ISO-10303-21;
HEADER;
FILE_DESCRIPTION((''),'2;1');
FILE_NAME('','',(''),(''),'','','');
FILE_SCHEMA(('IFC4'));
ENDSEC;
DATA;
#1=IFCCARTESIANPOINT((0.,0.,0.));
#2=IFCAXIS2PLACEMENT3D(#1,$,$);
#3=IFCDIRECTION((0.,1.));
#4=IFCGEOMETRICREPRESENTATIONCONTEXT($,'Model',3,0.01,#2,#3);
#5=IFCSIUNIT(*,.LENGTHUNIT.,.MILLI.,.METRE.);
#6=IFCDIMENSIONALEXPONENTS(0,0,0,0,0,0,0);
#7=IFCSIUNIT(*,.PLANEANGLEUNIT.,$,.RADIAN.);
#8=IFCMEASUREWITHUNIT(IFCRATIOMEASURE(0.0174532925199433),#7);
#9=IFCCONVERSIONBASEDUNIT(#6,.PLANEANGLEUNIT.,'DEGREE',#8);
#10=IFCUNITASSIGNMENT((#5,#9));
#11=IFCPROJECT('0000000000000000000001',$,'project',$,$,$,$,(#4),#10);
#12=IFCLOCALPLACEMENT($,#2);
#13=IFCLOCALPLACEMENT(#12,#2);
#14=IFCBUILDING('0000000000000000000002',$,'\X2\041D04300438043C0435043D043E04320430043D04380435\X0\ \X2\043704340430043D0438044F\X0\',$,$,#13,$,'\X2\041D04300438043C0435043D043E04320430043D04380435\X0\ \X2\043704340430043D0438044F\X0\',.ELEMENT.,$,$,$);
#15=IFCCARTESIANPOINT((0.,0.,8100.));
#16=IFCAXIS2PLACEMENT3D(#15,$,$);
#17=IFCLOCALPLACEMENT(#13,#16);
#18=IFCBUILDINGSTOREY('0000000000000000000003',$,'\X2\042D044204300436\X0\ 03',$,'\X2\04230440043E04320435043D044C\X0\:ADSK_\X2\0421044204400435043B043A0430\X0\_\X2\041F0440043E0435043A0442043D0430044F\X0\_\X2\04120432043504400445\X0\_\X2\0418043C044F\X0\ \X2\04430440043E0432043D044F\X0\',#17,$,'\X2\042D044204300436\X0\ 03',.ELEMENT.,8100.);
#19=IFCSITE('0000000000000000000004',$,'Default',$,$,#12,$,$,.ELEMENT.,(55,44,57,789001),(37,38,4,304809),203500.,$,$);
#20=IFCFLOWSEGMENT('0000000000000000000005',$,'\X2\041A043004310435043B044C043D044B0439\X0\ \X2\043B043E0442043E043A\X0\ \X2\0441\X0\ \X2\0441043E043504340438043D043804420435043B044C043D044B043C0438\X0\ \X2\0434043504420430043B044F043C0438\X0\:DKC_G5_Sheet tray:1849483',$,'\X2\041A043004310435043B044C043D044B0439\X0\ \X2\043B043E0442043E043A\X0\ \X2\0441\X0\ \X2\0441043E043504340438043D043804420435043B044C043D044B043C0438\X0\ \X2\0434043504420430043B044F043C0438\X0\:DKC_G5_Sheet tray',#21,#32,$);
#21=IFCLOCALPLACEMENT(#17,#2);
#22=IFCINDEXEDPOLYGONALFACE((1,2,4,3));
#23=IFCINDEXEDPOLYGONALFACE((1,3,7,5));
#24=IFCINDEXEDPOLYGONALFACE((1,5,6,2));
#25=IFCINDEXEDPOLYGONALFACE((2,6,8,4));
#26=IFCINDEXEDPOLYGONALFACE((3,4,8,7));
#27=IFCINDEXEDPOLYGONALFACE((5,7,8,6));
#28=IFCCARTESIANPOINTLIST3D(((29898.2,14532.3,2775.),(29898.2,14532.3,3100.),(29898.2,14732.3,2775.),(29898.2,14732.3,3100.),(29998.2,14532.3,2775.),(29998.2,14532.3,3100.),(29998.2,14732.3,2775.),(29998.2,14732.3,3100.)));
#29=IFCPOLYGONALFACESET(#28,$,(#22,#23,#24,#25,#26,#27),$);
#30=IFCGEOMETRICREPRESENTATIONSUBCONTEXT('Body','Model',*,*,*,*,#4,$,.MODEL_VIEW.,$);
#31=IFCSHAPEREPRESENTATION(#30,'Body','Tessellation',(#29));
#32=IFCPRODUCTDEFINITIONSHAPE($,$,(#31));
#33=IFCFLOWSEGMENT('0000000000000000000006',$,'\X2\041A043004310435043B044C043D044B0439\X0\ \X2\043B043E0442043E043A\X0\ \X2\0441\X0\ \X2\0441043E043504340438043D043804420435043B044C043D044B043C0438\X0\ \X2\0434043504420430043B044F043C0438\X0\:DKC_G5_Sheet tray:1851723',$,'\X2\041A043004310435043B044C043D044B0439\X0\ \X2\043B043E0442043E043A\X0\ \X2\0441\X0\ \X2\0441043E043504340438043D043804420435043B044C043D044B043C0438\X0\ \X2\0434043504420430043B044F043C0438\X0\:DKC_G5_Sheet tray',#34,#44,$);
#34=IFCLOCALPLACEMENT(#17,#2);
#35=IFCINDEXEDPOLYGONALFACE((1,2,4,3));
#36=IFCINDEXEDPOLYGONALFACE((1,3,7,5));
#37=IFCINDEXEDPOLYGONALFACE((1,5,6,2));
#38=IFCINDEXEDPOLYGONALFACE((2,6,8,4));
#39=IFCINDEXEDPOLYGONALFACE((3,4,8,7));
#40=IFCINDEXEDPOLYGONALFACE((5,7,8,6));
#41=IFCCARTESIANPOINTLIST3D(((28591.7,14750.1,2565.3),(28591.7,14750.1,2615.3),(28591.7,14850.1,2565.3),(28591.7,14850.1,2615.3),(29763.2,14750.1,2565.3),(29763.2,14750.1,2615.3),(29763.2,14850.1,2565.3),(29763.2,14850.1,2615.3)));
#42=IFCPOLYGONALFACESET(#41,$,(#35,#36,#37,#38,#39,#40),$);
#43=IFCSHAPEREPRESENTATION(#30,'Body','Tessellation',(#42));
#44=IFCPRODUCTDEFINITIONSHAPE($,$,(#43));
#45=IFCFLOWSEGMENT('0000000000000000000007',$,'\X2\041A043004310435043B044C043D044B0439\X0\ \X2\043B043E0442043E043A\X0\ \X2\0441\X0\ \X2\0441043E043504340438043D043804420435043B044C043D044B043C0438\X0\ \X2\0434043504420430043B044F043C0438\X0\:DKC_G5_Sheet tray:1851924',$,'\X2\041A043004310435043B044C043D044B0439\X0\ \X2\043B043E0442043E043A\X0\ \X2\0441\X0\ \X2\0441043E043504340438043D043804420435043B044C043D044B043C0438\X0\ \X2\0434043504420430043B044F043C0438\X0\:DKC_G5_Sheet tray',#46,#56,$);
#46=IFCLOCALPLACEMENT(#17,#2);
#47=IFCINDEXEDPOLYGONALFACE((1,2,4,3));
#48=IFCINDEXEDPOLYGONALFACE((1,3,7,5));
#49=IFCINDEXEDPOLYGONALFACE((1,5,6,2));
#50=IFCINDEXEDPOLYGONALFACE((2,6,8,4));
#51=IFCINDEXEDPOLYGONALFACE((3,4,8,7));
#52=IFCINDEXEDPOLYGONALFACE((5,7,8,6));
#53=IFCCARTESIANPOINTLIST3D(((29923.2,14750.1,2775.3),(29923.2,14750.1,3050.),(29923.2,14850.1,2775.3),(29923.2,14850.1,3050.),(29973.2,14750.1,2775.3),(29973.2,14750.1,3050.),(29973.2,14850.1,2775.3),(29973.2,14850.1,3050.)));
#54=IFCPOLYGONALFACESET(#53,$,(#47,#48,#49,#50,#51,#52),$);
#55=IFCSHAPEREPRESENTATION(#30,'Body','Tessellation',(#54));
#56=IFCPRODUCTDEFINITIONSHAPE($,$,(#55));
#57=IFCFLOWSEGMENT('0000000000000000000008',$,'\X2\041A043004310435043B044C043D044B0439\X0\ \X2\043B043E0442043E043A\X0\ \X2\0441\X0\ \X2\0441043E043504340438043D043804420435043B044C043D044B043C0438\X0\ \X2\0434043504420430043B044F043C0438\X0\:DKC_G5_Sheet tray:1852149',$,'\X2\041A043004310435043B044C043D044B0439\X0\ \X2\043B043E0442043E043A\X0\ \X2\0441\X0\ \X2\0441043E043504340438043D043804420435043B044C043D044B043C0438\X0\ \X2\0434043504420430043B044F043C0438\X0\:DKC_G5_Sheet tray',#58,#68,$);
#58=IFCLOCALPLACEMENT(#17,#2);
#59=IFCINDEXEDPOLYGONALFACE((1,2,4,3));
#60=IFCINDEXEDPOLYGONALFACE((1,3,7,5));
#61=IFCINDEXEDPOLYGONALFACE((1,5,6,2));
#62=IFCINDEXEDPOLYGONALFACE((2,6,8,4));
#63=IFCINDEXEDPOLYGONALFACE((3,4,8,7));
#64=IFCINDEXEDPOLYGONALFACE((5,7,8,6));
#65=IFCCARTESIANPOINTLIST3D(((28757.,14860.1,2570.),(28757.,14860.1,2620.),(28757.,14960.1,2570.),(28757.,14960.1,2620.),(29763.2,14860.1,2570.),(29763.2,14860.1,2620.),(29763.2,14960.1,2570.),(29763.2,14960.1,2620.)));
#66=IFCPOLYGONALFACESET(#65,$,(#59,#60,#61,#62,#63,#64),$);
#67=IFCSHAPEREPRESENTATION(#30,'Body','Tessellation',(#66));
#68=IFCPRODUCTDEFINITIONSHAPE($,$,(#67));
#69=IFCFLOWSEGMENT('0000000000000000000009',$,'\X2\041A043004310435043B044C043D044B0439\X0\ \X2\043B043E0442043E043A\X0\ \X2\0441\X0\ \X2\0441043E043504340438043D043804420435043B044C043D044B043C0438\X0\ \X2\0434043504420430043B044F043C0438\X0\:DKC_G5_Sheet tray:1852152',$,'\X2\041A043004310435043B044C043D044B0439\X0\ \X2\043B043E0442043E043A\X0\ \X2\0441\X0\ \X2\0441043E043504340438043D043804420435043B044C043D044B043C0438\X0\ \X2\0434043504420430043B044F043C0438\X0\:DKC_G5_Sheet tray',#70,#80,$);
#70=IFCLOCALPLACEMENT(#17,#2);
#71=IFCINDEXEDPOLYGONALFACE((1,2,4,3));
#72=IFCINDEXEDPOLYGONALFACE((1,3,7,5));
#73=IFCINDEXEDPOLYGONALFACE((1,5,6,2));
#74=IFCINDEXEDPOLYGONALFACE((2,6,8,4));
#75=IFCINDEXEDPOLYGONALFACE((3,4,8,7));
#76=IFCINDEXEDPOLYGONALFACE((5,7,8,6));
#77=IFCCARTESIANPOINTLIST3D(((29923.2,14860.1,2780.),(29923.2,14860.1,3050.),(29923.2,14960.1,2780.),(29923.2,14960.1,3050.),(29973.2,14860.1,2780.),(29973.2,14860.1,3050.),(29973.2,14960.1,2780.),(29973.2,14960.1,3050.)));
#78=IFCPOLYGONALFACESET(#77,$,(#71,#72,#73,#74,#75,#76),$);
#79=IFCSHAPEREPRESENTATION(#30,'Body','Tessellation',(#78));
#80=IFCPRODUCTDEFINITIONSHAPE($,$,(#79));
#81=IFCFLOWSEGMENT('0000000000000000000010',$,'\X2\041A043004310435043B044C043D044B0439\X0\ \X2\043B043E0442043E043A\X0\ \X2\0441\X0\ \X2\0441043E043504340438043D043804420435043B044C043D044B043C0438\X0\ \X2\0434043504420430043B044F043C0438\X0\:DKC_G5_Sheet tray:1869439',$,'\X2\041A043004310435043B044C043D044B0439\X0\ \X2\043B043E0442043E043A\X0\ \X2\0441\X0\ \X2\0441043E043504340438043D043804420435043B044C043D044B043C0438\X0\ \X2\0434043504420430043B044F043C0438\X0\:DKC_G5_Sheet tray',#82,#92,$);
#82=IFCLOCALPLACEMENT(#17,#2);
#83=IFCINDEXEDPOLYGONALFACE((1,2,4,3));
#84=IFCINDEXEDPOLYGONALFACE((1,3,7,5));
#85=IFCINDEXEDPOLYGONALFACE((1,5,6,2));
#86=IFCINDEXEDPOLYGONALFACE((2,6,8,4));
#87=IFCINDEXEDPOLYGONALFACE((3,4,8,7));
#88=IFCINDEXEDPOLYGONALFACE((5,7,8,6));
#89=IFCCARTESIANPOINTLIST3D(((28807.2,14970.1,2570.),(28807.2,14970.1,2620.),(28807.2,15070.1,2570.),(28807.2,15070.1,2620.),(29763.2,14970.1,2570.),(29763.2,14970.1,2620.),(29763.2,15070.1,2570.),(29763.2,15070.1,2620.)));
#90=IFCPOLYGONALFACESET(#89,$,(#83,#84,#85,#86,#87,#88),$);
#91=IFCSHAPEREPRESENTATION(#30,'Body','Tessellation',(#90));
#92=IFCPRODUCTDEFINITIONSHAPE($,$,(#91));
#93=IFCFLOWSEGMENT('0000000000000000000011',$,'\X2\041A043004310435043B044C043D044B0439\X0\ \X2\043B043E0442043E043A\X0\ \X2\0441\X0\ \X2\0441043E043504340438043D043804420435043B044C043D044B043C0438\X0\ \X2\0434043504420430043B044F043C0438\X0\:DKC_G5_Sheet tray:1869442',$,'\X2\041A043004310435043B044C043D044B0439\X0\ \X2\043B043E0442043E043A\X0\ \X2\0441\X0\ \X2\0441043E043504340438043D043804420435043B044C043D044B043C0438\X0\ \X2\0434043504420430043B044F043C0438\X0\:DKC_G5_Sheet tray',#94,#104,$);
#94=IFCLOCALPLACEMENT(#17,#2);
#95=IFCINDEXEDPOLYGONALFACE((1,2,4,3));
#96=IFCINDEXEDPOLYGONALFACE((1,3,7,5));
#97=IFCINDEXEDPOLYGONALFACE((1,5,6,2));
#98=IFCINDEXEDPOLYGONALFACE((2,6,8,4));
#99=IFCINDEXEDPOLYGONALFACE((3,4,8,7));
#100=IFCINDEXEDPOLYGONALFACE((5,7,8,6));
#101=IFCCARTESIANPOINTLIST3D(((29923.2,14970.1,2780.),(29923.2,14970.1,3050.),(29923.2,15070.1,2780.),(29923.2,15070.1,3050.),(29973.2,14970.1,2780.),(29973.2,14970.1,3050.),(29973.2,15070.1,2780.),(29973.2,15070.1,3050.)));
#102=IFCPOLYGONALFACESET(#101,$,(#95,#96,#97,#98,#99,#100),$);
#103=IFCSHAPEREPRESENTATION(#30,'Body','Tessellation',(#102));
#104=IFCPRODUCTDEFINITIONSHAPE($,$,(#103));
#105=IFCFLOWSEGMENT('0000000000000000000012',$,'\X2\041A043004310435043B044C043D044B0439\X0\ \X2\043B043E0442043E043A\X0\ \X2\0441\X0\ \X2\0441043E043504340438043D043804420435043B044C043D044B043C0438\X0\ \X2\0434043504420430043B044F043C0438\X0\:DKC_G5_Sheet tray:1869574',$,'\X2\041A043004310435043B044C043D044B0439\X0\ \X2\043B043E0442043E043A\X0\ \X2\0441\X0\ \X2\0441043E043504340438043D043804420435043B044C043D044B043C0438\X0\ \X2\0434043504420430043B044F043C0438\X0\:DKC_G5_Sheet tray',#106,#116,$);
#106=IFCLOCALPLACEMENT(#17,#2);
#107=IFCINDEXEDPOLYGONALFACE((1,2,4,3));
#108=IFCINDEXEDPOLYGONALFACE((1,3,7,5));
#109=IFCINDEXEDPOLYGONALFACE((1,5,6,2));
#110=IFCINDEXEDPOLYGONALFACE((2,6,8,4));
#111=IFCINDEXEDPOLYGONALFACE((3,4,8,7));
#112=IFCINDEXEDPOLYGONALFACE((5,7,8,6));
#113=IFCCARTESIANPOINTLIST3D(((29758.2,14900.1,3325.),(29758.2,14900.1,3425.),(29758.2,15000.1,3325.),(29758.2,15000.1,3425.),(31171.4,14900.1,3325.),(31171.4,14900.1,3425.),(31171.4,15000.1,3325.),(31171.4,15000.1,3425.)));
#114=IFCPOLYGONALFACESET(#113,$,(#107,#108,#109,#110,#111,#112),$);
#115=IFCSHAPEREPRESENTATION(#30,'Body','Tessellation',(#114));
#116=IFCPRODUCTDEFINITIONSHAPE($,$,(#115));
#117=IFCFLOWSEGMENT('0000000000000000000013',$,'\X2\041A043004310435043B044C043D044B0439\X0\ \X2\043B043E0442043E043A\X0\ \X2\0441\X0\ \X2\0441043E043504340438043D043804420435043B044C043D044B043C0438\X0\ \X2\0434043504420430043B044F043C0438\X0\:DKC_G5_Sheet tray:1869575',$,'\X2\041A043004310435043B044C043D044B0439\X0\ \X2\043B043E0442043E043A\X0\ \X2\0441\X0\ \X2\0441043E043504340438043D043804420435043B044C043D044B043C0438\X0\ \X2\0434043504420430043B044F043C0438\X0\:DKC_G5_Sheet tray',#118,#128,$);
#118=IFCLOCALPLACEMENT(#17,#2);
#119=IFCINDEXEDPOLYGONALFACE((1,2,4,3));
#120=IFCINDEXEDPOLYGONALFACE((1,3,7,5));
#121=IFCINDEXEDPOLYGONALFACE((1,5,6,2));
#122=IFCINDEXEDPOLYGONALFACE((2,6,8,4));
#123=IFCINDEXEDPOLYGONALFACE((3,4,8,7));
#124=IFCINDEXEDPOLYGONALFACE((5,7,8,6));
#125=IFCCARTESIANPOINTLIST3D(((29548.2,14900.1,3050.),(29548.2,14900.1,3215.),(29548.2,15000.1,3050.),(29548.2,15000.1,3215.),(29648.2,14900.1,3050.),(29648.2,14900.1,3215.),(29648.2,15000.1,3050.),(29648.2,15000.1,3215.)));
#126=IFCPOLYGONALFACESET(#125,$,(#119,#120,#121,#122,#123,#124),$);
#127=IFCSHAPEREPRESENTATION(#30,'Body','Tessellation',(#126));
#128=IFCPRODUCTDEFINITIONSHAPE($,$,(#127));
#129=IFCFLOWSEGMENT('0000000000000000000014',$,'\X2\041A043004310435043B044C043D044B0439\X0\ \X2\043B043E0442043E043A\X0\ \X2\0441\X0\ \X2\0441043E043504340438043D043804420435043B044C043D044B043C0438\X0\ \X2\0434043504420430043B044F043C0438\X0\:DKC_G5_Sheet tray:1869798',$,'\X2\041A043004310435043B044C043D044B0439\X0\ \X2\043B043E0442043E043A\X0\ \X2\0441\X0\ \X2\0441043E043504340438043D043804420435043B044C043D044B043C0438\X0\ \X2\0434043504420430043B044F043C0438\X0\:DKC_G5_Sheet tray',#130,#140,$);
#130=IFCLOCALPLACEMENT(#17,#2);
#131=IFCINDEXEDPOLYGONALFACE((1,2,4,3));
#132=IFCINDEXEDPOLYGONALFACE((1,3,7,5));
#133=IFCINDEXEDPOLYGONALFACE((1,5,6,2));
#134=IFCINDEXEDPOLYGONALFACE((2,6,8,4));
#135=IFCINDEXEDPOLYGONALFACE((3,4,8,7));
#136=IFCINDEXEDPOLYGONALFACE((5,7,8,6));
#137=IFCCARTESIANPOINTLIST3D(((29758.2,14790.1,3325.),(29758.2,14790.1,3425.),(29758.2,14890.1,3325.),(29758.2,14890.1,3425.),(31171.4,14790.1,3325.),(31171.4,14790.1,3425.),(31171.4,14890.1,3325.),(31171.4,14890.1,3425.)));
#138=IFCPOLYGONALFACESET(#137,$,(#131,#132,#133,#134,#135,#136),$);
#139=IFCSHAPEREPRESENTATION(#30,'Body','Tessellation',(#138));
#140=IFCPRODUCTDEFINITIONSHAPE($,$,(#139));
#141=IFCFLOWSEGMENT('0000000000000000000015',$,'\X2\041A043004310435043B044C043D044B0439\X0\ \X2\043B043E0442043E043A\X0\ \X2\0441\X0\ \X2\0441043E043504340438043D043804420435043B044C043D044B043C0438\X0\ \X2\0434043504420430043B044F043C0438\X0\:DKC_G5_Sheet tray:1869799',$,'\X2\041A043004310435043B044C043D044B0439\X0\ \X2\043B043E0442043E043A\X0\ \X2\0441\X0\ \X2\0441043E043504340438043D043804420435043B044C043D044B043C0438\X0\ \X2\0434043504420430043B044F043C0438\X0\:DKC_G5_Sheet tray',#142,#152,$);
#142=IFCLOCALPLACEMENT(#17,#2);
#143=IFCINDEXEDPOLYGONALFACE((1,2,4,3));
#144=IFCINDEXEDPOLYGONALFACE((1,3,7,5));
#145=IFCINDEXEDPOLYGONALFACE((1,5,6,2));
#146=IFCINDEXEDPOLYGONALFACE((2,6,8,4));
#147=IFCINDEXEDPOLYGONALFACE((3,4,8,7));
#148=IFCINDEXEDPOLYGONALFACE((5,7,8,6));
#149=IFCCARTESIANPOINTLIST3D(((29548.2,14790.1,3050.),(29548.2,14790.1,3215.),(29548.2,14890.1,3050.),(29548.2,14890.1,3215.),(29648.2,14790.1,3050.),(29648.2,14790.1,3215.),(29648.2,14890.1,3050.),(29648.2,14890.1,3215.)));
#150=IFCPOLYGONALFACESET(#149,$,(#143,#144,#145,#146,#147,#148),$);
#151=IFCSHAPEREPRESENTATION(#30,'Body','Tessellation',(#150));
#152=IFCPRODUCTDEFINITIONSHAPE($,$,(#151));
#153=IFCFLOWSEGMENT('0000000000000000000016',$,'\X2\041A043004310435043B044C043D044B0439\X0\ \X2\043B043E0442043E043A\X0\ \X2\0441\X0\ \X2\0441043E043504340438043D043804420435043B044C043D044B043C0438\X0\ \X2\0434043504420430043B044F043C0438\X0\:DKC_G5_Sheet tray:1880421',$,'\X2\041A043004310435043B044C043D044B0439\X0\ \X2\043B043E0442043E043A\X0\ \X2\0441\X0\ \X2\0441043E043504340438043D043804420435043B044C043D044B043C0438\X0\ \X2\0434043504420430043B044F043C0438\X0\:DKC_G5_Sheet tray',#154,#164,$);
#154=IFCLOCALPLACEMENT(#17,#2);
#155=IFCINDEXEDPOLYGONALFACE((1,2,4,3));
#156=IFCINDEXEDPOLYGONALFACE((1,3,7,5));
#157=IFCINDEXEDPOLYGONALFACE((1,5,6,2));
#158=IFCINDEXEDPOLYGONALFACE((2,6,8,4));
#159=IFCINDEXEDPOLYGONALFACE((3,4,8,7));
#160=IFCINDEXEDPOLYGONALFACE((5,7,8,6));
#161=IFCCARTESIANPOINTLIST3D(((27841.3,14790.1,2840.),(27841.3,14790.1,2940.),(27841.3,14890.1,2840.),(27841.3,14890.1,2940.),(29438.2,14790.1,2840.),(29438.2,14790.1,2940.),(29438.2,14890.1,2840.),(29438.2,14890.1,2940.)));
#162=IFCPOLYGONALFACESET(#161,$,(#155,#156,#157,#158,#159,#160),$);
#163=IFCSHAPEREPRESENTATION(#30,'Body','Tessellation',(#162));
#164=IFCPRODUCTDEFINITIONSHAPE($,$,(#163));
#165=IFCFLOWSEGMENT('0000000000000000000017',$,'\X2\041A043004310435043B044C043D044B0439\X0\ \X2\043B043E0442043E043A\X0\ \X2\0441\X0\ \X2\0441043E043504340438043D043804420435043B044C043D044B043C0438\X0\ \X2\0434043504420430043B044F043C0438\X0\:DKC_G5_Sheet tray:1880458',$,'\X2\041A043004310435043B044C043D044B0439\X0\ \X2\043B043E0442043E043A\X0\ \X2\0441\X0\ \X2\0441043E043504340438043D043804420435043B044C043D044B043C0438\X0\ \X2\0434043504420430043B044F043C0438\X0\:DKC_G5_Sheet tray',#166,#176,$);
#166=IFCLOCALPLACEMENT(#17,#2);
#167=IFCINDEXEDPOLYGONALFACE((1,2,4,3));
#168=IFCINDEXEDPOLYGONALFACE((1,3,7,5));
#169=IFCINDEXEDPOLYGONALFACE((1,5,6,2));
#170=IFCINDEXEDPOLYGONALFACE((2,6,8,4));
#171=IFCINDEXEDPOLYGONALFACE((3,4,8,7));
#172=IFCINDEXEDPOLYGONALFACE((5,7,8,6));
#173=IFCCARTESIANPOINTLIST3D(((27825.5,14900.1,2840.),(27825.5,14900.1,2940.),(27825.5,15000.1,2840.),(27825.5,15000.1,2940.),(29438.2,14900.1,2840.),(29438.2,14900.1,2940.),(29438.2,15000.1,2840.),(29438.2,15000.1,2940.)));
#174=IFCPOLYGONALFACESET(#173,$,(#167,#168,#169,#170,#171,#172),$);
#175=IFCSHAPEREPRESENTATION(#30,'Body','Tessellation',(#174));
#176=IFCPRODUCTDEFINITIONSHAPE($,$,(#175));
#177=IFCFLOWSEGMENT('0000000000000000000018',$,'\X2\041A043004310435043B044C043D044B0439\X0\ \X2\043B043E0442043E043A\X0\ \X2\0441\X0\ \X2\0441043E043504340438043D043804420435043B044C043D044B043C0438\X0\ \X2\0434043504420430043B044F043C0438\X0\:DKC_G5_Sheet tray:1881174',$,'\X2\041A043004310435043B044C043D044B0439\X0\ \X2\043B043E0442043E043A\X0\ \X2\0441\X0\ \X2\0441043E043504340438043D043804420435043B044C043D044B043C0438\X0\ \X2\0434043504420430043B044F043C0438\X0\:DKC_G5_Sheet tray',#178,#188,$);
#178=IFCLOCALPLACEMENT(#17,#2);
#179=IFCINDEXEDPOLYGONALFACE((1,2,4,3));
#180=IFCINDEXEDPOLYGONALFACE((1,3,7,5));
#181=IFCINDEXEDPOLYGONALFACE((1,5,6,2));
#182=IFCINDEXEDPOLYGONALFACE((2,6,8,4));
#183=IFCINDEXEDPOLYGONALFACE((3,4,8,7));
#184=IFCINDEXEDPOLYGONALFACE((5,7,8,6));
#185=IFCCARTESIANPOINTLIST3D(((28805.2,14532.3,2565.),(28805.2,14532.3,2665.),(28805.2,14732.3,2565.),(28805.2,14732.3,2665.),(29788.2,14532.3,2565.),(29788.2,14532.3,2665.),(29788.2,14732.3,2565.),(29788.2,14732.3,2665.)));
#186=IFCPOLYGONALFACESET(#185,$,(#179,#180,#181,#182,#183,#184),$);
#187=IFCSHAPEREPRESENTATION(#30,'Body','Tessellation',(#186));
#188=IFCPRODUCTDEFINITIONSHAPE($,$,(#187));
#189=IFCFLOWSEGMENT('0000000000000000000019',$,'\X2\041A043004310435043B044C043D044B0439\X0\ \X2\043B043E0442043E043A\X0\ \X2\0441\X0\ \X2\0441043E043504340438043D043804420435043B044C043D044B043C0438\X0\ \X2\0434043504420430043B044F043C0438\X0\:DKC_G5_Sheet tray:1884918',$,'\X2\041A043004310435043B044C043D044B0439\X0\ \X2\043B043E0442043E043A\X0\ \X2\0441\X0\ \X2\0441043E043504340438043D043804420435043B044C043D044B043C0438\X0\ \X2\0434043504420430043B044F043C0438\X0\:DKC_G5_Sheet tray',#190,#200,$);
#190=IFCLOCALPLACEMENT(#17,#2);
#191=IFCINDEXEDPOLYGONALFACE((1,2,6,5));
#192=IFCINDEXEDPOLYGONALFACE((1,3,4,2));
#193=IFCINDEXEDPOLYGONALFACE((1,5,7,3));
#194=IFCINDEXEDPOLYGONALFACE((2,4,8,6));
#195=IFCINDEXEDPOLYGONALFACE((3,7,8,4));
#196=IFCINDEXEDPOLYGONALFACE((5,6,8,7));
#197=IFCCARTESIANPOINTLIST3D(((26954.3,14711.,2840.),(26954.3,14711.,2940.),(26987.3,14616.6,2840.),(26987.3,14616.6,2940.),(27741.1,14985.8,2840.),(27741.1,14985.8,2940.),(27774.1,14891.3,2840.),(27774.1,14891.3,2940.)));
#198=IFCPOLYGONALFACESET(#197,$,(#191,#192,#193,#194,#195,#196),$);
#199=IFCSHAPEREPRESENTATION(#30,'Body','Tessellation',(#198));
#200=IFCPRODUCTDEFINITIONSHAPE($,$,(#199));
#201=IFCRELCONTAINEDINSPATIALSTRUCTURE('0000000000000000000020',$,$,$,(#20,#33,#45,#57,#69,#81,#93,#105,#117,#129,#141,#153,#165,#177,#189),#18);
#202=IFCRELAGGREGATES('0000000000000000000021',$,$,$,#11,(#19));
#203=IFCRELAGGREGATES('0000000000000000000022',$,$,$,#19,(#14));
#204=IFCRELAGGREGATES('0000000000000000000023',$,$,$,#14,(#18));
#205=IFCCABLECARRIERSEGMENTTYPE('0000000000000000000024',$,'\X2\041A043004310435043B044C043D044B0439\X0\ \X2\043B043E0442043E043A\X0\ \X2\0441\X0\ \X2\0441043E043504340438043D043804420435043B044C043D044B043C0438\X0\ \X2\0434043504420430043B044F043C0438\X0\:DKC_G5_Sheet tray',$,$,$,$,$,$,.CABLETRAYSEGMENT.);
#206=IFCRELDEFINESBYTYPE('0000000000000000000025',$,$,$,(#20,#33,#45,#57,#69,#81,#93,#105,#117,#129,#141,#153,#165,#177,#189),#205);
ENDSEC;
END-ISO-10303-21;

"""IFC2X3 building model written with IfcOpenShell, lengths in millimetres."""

from ifc_helpers import new_model, entity, si_unit, converted_unit, direction, frame, frame_2d, origin, origin_2d_with_axis, place, context, subcontext, project, spatial, rectangle, extrude, type_object, element, save


model = new_model("IFC2X3")

# Units and contexts
model_context = context("Model", 3, precision=0.01, world=origin(), true_north=direction((0.0, 1.0)))
body_context = subcontext(model_context, "Body", "Model", "MODEL_VIEW")
ifc_project = project(units=[si_unit("LENGTHUNIT", "METRE", prefix="MILLI"), converted_unit("PLANEANGLEUNIT", "DEGREE", entity("IfcRatioMeasure", 0.0174532925199433), si_unit("PLANEANGLEUNIT", "RADIAN"), dimensions=[0, 0, 0, 0, 0, 0, 0])], contexts=[model_context])

# Site, building, storey
site_placement = place(None, frame((0.0, 0.0, 0.0)))
site = spatial("IfcSite", under=ifc_project, at=site_placement, Name="Default", CompositionType="ELEMENT", RefLatitude=(55, 44, 57, 789001), RefLongitude=(37, 38, 4, 304809), RefElevation=203500.0)
building_placement = place(site_placement, origin())
building = spatial("IfcBuilding", under=site, at=building_placement, Name="Наименование здания", LongName="Наименование здания", CompositionType="ELEMENT")
storey_placement = place(building_placement, frame((0.0, 0.0, 8100.0)))
storey = spatial("IfcBuildingStorey", under=building, at=storey_placement, Name="Этаж 03", ObjectType="Уровень:ADSK_Стрелка_Проектная_Вверх_Имя уровня", LongName="Этаж 03", CompositionType="ELEMENT", Elevation=8100.0)

# Flow segments
cable_carrier_segment_type = type_object("IfcCableCarrierSegmentType", Name="Кабельный лоток с соединительными деталями:DKC_G5_Sheet tray", PredefinedType="CABLETRAYSEGMENT")
flow_segment_1_placement = place(storey_placement, frame((29898.2, 14532.3, 2775.0)))
element("IfcFlowSegment", 1, at=flow_segment_1_placement, inside=storey, type_object=cable_carrier_segment_type, Name="Кабельный лоток с соединительными деталями:DKC_G5_Sheet tray:1849483", ObjectType="Кабельный лоток с соединительными деталями:DKC_G5_Sheet tray", context=body_context, shape_type="SweptSolid", body=[
    extrude(rectangle(XDim=200.0, YDim=100.0, at=origin_2d_with_axis()), frame((50.0, 100.0, 0.0), z_axis=(0.0, 0.0, 1.0), x_axis=(0.0, 1.0, 0.0)), (0.0, 0.0, 1.0), 325.0),
])
flow_segment_2_placement = place(storey_placement, frame((28591.7, 14750.1, 2565.3)))
element("IfcFlowSegment", 2, at=flow_segment_2_placement, inside=storey, type_object=cable_carrier_segment_type, Name="Кабельный лоток с соединительными деталями:DKC_G5_Sheet tray:1851723", ObjectType="Кабельный лоток с соединительными деталями:DKC_G5_Sheet tray", context=body_context, shape_type="SweptSolid", body=[
    extrude(rectangle(XDim=1171.5, YDim=100.0, at=origin_2d_with_axis()), frame((585.8, 50.0, 0.0), z_axis=(0.0, 0.0, 1.0), x_axis=(-1.0, 0.0, 0.0)), (0.0, 0.0, 1.0), 50.0),
])
flow_segment_3_placement = place(storey_placement, frame((29923.2, 14750.1, 2775.3)))
element("IfcFlowSegment", 3, at=flow_segment_3_placement, inside=storey, type_object=cable_carrier_segment_type, Name="Кабельный лоток с соединительными деталями:DKC_G5_Sheet tray:1851924", ObjectType="Кабельный лоток с соединительными деталями:DKC_G5_Sheet tray", context=body_context, shape_type="SweptSolid", body=[
    extrude(rectangle(XDim=100.0, YDim=50.0, at=origin_2d_with_axis()), frame((25.0, 50.0, 0.0), z_axis=(0.0, 0.0, 1.0), x_axis=(0.0, 1.0, 0.0)), (0.0, 0.0, 1.0), 274.7),
])
flow_segment_4_placement = place(storey_placement, frame((28757.0, 14860.1, 2570.0)))
element("IfcFlowSegment", 4, at=flow_segment_4_placement, inside=storey, type_object=cable_carrier_segment_type, Name="Кабельный лоток с соединительными деталями:DKC_G5_Sheet tray:1852149", ObjectType="Кабельный лоток с соединительными деталями:DKC_G5_Sheet tray", context=body_context, shape_type="SweptSolid", body=[
    extrude(rectangle(XDim=1006.2, YDim=100.0, at=frame_2d((0.0, 0.0), x_axis=(1.0, 0.0))), frame((503.1, 50.0, 0.0), z_axis=(0.0, 0.0, 1.0), x_axis=(-1.0, 0.0, 0.0)), (0.0, 0.0, 1.0), 50.0),
])
flow_segment_5_placement = place(storey_placement, frame((29923.2, 14860.1, 2780.0)))
element("IfcFlowSegment", 5, at=flow_segment_5_placement, inside=storey, type_object=cable_carrier_segment_type, Name="Кабельный лоток с соединительными деталями:DKC_G5_Sheet tray:1852152", ObjectType="Кабельный лоток с соединительными деталями:DKC_G5_Sheet tray", context=body_context, shape_type="SweptSolid", body=[
    extrude(rectangle(XDim=100.0, YDim=50.0, at=origin_2d_with_axis()), frame((25.0, 50.0, 0.0), z_axis=(0.0, 0.0, 1.0), x_axis=(0.0, 1.0, 0.0)), (0.0, 0.0, 1.0), 270.0),
])
flow_segment_6_placement = place(storey_placement, frame((28807.2, 14970.1, 2570.0)))
element("IfcFlowSegment", 6, at=flow_segment_6_placement, inside=storey, type_object=cable_carrier_segment_type, Name="Кабельный лоток с соединительными деталями:DKC_G5_Sheet tray:1869439", ObjectType="Кабельный лоток с соединительными деталями:DKC_G5_Sheet tray", context=body_context, shape_type="SweptSolid", body=[
    extrude(rectangle(XDim=956.0, YDim=100.0, at=origin_2d_with_axis()), frame((478.0, 50.0, 0.0), z_axis=(0.0, 0.0, 1.0), x_axis=(-1.0, 0.0, 0.0)), (0.0, 0.0, 1.0), 50.0),
])
flow_segment_7_placement = place(storey_placement, frame((29923.2, 14970.1, 2780.0)))
element("IfcFlowSegment", 7, at=flow_segment_7_placement, inside=storey, type_object=cable_carrier_segment_type, Name="Кабельный лоток с соединительными деталями:DKC_G5_Sheet tray:1869442", ObjectType="Кабельный лоток с соединительными деталями:DKC_G5_Sheet tray", context=body_context, shape_type="SweptSolid", body=[
    extrude(rectangle(XDim=100.0, YDim=50.0, at=origin_2d_with_axis()), frame((25.0, 50.0, 0.0), z_axis=(0.0, 0.0, 1.0), x_axis=(0.0, 1.0, 0.0)), (0.0, 0.0, 1.0), 270.0),
])
flow_segment_8_placement = place(storey_placement, frame((29758.2, 14900.1, 3325.0)))
element("IfcFlowSegment", 8, at=flow_segment_8_placement, inside=storey, type_object=cable_carrier_segment_type, Name="Кабельный лоток с соединительными деталями:DKC_G5_Sheet tray:1869574", ObjectType="Кабельный лоток с соединительными деталями:DKC_G5_Sheet tray", context=body_context, shape_type="SweptSolid", body=[
    extrude(rectangle(XDim=1413.2, YDim=100.0, at=frame_2d((0.0, 0.0), x_axis=(1.0, 0.0))), frame((706.6, 50.0, 0.0)), (0.0, 0.0, 1.0), 100.0),
])
flow_segment_9_placement = place(storey_placement, frame((29548.2, 14900.1, 3050.0)))
element("IfcFlowSegment", 9, at=flow_segment_9_placement, inside=storey, type_object=cable_carrier_segment_type, Name="Кабельный лоток с соединительными деталями:DKC_G5_Sheet tray:1869575", ObjectType="Кабельный лоток с соединительными деталями:DKC_G5_Sheet tray", context=body_context, shape_type="SweptSolid", body=[
    extrude(rectangle(XDim=100.0, YDim=100.0, at=frame_2d((0.0, 0.0), x_axis=(1.0, 0.0))), frame((50.0, 50.0, 0.0), z_axis=(0.0, 0.0, 1.0), x_axis=(0.0, 1.0, 0.0)), (0.0, 0.0, 1.0), 165.0),
])
flow_segment_10_placement = place(storey_placement, frame((29758.2, 14790.1, 3325.0)))
element("IfcFlowSegment", 10, at=flow_segment_10_placement, inside=storey, type_object=cable_carrier_segment_type, Name="Кабельный лоток с соединительными деталями:DKC_G5_Sheet tray:1869798", ObjectType="Кабельный лоток с соединительными деталями:DKC_G5_Sheet tray", context=body_context, shape_type="SweptSolid", body=[
    extrude(rectangle(XDim=1413.2, YDim=100.0, at=origin_2d_with_axis()), frame((706.6, 50.0, 0.0)), (0.0, 0.0, 1.0), 100.0),
])
flow_segment_11_placement = place(storey_placement, frame((29548.2, 14790.1, 3050.0)))
element("IfcFlowSegment", 11, at=flow_segment_11_placement, inside=storey, type_object=cable_carrier_segment_type, Name="Кабельный лоток с соединительными деталями:DKC_G5_Sheet tray:1869799", ObjectType="Кабельный лоток с соединительными деталями:DKC_G5_Sheet tray", context=body_context, shape_type="SweptSolid", body=[
    extrude(rectangle(XDim=100.0, YDim=100.0, at=origin_2d_with_axis()), frame((50.0, 50.0, 0.0), z_axis=(0.0, 0.0, 1.0), x_axis=(0.0, 1.0, 0.0)), (0.0, 0.0, 1.0), 165.0),
])
flow_segment_12_placement = place(storey_placement, frame((27841.3, 14790.1, 2840.0)))
element("IfcFlowSegment", 12, at=flow_segment_12_placement, inside=storey, type_object=cable_carrier_segment_type, Name="Кабельный лоток с соединительными деталями:DKC_G5_Sheet tray:1880421", ObjectType="Кабельный лоток с соединительными деталями:DKC_G5_Sheet tray", context=body_context, shape_type="SweptSolid", body=[
    extrude(rectangle(XDim=1596.9, YDim=100.0, at=frame_2d((0.0, 0.0), x_axis=(1.0, 0.0))), frame((798.5, 50.0, 0.0), z_axis=(0.0, 0.0, 1.0), x_axis=(-1.0, 0.0, 0.0)), (0.0, 0.0, 1.0), 100.0),
])
flow_segment_13_placement = place(storey_placement, frame((27825.5, 14900.1, 2840.0)))
element("IfcFlowSegment", 13, at=flow_segment_13_placement, inside=storey, type_object=cable_carrier_segment_type, Name="Кабельный лоток с соединительными деталями:DKC_G5_Sheet tray:1880458", ObjectType="Кабельный лоток с соединительными деталями:DKC_G5_Sheet tray", context=body_context, shape_type="SweptSolid", body=[
    extrude(rectangle(XDim=1612.7, YDim=100.0, at=frame_2d((0.0, 0.0), x_axis=(1.0, 0.0))), frame((806.3, 50.0, 0.0), z_axis=(0.0, 0.0, 1.0), x_axis=(-1.0, 0.0, 0.0)), (0.0, 0.0, 1.0), 100.0),
])
flow_segment_14_placement = place(storey_placement, frame((28805.2, 14532.3, 2565.0)))
element("IfcFlowSegment", 14, at=flow_segment_14_placement, inside=storey, type_object=cable_carrier_segment_type, Name="Кабельный лоток с соединительными деталями:DKC_G5_Sheet tray:1881174", ObjectType="Кабельный лоток с соединительными деталями:DKC_G5_Sheet tray", context=body_context, shape_type="SweptSolid", body=[
    extrude(rectangle(XDim=983.0, YDim=200.0, at=frame_2d((0.0, 0.0), x_axis=(1.0, 0.0))), frame((491.5, 100.0, 0.0), z_axis=(0.0, 0.0, 1.0), x_axis=(-1.0, 0.0, 0.0)), (0.0, 0.0, 1.0), 100.0),
])
flow_segment_15_placement = place(storey_placement, frame((26954.3, 14616.6, 2840.0)))
element("IfcFlowSegment", 15, at=flow_segment_15_placement, inside=storey, type_object=cable_carrier_segment_type, Name="Кабельный лоток с соединительными деталями:DKC_G5_Sheet tray:1884918", ObjectType="Кабельный лоток с соединительными деталями:DKC_G5_Sheet tray", context=body_context, shape_type="SweptSolid", body=[
    extrude(rectangle(XDim=833.4, YDim=100.0, at=frame_2d((0.0, 0.0), x_axis=(1.0, 0.0))), frame((409.9, 184.6, 0.0), z_axis=(0.0, 0.0, 1.0), x_axis=(-0.944095, -0.329672, 0.0)), (0.0, 0.0, 1.0), 100.0),
])

save(model, "model.ifc")
